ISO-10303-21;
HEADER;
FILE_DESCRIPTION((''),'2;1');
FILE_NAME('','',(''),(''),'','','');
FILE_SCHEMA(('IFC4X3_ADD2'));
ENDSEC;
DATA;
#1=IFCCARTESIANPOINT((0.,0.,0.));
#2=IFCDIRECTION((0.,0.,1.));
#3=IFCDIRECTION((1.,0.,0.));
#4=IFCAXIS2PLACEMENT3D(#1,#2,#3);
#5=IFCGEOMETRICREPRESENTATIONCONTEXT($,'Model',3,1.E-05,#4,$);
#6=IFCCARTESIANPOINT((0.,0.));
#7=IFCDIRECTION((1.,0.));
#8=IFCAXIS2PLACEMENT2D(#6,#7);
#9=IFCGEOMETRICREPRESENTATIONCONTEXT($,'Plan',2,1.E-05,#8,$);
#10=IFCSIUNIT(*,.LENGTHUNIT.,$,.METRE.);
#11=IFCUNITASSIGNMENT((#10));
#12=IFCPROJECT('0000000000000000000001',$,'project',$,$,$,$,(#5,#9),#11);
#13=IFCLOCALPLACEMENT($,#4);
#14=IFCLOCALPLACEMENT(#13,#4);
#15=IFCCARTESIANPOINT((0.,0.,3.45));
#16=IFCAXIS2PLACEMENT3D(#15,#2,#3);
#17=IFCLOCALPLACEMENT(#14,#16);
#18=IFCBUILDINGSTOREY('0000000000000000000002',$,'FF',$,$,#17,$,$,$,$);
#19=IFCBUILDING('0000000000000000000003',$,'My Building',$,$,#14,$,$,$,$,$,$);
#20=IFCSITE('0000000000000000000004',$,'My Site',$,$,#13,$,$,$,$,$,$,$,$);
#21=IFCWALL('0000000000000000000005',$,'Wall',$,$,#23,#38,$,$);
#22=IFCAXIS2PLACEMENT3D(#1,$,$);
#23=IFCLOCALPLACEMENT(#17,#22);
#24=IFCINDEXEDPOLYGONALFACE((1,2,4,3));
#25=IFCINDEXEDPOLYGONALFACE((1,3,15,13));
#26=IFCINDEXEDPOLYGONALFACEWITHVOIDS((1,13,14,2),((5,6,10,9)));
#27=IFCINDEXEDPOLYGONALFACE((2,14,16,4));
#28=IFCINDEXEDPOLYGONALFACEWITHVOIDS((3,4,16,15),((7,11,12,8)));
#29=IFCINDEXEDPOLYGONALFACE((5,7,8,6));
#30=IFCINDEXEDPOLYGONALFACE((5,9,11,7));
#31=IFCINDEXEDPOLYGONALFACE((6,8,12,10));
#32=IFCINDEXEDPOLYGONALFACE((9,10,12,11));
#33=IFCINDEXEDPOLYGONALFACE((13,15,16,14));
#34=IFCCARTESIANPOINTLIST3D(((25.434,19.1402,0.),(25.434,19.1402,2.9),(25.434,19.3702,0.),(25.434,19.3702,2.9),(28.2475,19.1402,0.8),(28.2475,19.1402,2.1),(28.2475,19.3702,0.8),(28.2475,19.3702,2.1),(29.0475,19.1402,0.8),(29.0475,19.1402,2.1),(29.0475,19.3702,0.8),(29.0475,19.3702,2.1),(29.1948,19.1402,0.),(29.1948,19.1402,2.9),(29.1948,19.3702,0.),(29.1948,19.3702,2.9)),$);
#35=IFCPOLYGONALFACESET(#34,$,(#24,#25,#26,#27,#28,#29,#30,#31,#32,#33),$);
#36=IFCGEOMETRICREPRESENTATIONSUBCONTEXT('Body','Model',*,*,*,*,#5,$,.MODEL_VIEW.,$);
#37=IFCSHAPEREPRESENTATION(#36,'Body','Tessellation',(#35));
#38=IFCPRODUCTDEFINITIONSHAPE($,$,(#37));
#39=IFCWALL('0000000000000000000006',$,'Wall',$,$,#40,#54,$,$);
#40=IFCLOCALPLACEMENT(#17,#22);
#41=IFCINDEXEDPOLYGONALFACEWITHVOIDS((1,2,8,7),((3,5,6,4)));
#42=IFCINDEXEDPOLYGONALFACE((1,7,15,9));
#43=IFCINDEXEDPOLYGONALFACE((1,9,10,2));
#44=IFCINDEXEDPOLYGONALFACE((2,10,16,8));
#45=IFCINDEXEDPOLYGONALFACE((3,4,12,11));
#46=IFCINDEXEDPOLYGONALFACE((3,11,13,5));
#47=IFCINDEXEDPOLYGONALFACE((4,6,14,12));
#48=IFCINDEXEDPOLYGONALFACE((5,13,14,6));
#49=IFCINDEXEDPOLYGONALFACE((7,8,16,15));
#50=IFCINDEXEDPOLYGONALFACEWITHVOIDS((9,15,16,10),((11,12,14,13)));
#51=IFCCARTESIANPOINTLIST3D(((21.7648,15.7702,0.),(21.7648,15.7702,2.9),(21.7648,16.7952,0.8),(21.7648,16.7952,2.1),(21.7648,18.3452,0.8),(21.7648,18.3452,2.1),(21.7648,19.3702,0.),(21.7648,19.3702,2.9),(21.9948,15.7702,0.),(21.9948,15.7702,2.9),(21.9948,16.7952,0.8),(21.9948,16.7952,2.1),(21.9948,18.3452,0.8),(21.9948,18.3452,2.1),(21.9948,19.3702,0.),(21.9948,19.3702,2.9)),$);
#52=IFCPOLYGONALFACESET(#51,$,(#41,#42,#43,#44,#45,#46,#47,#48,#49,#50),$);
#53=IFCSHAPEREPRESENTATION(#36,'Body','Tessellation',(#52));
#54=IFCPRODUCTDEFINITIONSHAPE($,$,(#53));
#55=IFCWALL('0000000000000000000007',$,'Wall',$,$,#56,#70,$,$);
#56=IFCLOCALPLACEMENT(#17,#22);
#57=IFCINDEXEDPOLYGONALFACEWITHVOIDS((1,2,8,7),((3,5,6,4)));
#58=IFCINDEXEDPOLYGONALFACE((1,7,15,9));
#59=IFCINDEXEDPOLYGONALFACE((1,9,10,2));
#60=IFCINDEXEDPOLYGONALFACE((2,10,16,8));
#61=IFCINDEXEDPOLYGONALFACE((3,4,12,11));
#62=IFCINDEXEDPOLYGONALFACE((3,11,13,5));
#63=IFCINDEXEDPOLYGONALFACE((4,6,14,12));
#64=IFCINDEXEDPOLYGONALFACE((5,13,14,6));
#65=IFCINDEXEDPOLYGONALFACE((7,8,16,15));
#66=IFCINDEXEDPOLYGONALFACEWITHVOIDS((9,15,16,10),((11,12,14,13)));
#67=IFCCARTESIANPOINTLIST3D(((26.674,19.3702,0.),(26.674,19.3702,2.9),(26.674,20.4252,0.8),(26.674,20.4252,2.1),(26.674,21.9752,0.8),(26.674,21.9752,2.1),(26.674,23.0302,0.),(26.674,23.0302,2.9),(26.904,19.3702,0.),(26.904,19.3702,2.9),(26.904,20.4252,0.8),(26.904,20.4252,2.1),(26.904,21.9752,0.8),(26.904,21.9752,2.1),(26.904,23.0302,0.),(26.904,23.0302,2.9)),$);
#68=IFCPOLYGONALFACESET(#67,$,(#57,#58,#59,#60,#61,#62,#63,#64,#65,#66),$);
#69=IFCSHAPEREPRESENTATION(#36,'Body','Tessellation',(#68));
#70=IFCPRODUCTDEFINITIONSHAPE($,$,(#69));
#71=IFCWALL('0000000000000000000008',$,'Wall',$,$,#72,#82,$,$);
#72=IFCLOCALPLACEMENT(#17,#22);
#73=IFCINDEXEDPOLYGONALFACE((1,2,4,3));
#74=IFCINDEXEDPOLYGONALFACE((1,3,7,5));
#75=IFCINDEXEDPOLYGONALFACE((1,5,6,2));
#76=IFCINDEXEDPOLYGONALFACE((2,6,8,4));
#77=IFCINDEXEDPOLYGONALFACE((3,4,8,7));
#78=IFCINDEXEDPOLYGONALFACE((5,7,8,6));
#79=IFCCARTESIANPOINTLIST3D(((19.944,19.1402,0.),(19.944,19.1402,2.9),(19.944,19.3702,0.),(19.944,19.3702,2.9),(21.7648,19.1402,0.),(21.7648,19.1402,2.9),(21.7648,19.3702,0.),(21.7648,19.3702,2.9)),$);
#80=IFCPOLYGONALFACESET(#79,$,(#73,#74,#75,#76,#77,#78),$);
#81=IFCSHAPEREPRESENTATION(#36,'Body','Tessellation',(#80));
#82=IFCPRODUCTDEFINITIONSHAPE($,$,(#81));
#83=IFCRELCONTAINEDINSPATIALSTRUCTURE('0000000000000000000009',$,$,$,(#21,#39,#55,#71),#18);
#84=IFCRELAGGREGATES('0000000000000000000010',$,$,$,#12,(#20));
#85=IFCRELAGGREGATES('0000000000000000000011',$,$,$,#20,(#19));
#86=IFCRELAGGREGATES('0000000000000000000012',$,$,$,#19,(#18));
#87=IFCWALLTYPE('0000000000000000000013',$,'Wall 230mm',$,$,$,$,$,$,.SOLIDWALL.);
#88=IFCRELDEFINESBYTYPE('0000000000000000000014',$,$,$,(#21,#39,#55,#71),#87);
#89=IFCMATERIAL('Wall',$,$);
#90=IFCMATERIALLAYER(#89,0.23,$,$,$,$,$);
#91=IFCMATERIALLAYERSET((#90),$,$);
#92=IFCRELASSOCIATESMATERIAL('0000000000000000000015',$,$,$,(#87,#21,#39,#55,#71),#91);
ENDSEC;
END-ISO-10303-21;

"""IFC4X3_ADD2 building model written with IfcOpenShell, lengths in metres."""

from ifc_helpers import new_model, si_unit, frame, origin_with_axes, origin_2d_with_axis, place, context, subcontext, project, spatial, line, indexed_curve, outline, extrude, source, transform, mapped, material, layer, layer_set, layer_usage, type_object, element, save


model = new_model("IFC4X3_ADD2")

# Units and contexts
model_context = context("Model", 3, precision=1e-05, world=origin_with_axes())
plan_context = context("Plan", 2, precision=1e-05, world=origin_2d_with_axis())
body_context_1 = subcontext(model_context, "Body", "Model", "MODEL_VIEW")
ifc_project = project(units=[si_unit("LENGTHUNIT", "METRE")], contexts=[model_context, plan_context])

# Site, building, storey
site_placement = place(None, origin_with_axes())
site = spatial("IfcSite", under=ifc_project, at=site_placement, Name="My Site")
building_placement = place(site_placement, origin_with_axes())
building = spatial("IfcBuilding", under=site, at=building_placement, Name="My Building")
storey_placement = place(building_placement, frame((0.0, 0.0, 3.45), z_axis=(0.0, 0.0, 1.0), x_axis=(1.0, 0.0, 0.0)))
storey = spatial("IfcBuildingStorey", under=building, at=storey_placement, Name="FF")

# Shared definitions
ifc_material_1 = material(Name="Wall")

# Shared definitions
ifc_layer_1 = layer(ifc_material_1, 0.23)
ifc_layer_set_1 = layer_set([ifc_layer_1])
wall_type_1 = type_object("IfcWallType", Name="Wall 230mm", PredefinedType="SOLIDWALL", material=ifc_layer_set_1)
shared_shape_1 = source(origin_with_axes(), body_context_1, "Body", "SweptSolid", [
    extrude(outline(indexed_curve([(0.0, 0.0), (1.55, 0.0), (1.55, 1.3), (0.0, 1.3)], segments=[line(1, 2, 3, 4, 1)])), frame((-0.775, -0.6, 0.0), z_axis=(0.0, -1.0, 0.0), x_axis=(1.0, 0.0, 0.0)), (0.0, 0.0, -1.0), 1.2),
])

# Walls, openings
ifc_layer_usage_1 = layer_usage(ifc_layer_set_1, "AXIS2", "POSITIVE", 0.0)
wall_1_placement = place(storey_placement, frame((29.1948, 19.3702, 0.0), z_axis=(0.0, 0.0, 1.0), x_axis=(-1.0, 0.0, 0.0)))
wall_1 = element("IfcWall", 1, at=wall_1_placement, inside=storey, type_object=wall_type_1, material=ifc_layer_usage_1, Name="Wall", context=body_context_1, shape_type="SweptSolid", body=[
    extrude(outline(indexed_curve([(0.0, 0.0), (0.0, 0.23), (3.7608, 0.23), (3.7608, 0.0), (0.0, 0.0)], self_intersect=False)), origin_with_axes(), (0.0, 0.0, 1.0), 2.9),
])
shared_shape_2 = source(origin_with_axes(), body_context_1, "Body", "SweptSolid", [
    extrude(outline(indexed_curve([(0.0, 0.0), (0.8, 0.0), (0.8, 1.3), (0.0, 1.3)], segments=[line(1, 2, 3, 4, 1)])), frame((-0.4, -0.6, 0.0), z_axis=(0.0, -1.0, 0.0), x_axis=(1.0, 0.0, 0.0)), (0.0, 0.0, -1.0), 1.2),
])
opening_1_placement = place(wall_1_placement, frame((0.5473, 0.0, 0.8), z_axis=(0.0, 0.0, 1.0), x_axis=(1.0, 0.0, 0.0)))
element("IfcOpeningElement", 2, at=opening_1_placement, cuts=wall_1, PredefinedType="OPENING", context=body_context_1, shape_type="MappedRepresentation", body=[
    mapped(shared_shape_2, transform((0.0, 0.0, 0.0), x_axis=(1.0, 0.0, 0.0), y_axis=(0.0, 1.0, 0.0), z_axis=(0.0, 0.0, 1.0), scale=1.0)),
])
ifc_layer_usage_2 = layer_usage(ifc_layer_set_1, "AXIS2", "POSITIVE", 0.0)
wall_2_placement = place(storey_placement, frame((21.9948, 15.7702, 0.0), z_axis=(0.0, 0.0, 1.0), x_axis=(0.000001, 1.0, 0.0)))
wall_2 = element("IfcWall", 3, at=wall_2_placement, inside=storey, type_object=wall_type_1, material=ifc_layer_usage_2, Name="Wall", context=body_context_1, shape_type="SweptSolid", body=[
    extrude(outline(indexed_curve([(0.0, 0.0), (0.0, 0.23), (3.6, 0.23), (3.6, 0.0), (0.0, 0.0)], self_intersect=False)), origin_with_axes(), (0.0, 0.0, 1.0), 2.9),
])
opening_2_placement = place(wall_2_placement, frame((1.8, 0.0, 0.8), z_axis=(0.0, 0.0, 1.0), x_axis=(1.0, 0.0, 0.0)))
element("IfcOpeningElement", 4, at=opening_2_placement, cuts=wall_2, PredefinedType="OPENING", context=body_context_1, shape_type="MappedRepresentation", body=[
    mapped(shared_shape_1, transform((0.0, 0.0, 0.0), x_axis=(1.0, 0.0, 0.0), y_axis=(0.0, 1.0, 0.0), z_axis=(0.0, 0.0, 1.0), scale=1.0)),
])
ifc_layer_usage_3 = layer_usage(ifc_layer_set_1, "AXIS2", "POSITIVE", 0.0)
wall_3_placement = place(storey_placement, frame((26.904, 19.3702, 0.0), z_axis=(0.0, 0.0, 1.0), x_axis=(0.000001, 1.0, 0.0)))
wall_3 = element("IfcWall", 5, at=wall_3_placement, inside=storey, type_object=wall_type_1, material=ifc_layer_usage_3, Name="Wall", context=body_context_1, shape_type="SweptSolid", body=[
    extrude(outline(indexed_curve([(0.0, 0.0), (0.0, 0.23), (3.66, 0.23), (3.66, 0.0), (0.0, 0.0)], self_intersect=False)), origin_with_axes(), (0.0, 0.0, 1.0), 2.9),
])
opening_3_placement = place(wall_3_placement, frame((1.83, 0.0, 0.8), z_axis=(0.0, 0.0, 1.0), x_axis=(1.0, 0.0, 0.0)))
element("IfcOpeningElement", 6, at=opening_3_placement, cuts=wall_3, PredefinedType="OPENING", context=body_context_1, shape_type="MappedRepresentation", body=[
    mapped(shared_shape_1, transform((0.0, 0.0, 0.0), x_axis=(1.0, 0.0, 0.0), y_axis=(0.0, 1.0, 0.0), z_axis=(0.0, 0.0, 1.0), scale=1.0)),
])

# Wall
ifc_layer_usage_4 = layer_usage(ifc_layer_set_1, "AXIS2", "POSITIVE", 0.0)
wall_4_placement = place(storey_placement, frame((21.7648, 19.3702, 0.0), z_axis=(0.0, 0.0, 1.0), x_axis=(-1.0, 0.0, 0.0)))
element("IfcWall", 7, at=wall_4_placement, inside=storey, type_object=wall_type_1, material=ifc_layer_usage_4, Name="Wall", context=body_context_1, shape_type="SweptSolid", body=[
    extrude(outline(indexed_curve([(0.0, 0.0), (0.0, 0.23), (1.8208, 0.23), (1.8208, 0.0), (0.0, 0.0)], self_intersect=False)), origin_with_axes(), (0.0, 0.0, 1.0), 2.9),
])

save(model, "model.ifc")
